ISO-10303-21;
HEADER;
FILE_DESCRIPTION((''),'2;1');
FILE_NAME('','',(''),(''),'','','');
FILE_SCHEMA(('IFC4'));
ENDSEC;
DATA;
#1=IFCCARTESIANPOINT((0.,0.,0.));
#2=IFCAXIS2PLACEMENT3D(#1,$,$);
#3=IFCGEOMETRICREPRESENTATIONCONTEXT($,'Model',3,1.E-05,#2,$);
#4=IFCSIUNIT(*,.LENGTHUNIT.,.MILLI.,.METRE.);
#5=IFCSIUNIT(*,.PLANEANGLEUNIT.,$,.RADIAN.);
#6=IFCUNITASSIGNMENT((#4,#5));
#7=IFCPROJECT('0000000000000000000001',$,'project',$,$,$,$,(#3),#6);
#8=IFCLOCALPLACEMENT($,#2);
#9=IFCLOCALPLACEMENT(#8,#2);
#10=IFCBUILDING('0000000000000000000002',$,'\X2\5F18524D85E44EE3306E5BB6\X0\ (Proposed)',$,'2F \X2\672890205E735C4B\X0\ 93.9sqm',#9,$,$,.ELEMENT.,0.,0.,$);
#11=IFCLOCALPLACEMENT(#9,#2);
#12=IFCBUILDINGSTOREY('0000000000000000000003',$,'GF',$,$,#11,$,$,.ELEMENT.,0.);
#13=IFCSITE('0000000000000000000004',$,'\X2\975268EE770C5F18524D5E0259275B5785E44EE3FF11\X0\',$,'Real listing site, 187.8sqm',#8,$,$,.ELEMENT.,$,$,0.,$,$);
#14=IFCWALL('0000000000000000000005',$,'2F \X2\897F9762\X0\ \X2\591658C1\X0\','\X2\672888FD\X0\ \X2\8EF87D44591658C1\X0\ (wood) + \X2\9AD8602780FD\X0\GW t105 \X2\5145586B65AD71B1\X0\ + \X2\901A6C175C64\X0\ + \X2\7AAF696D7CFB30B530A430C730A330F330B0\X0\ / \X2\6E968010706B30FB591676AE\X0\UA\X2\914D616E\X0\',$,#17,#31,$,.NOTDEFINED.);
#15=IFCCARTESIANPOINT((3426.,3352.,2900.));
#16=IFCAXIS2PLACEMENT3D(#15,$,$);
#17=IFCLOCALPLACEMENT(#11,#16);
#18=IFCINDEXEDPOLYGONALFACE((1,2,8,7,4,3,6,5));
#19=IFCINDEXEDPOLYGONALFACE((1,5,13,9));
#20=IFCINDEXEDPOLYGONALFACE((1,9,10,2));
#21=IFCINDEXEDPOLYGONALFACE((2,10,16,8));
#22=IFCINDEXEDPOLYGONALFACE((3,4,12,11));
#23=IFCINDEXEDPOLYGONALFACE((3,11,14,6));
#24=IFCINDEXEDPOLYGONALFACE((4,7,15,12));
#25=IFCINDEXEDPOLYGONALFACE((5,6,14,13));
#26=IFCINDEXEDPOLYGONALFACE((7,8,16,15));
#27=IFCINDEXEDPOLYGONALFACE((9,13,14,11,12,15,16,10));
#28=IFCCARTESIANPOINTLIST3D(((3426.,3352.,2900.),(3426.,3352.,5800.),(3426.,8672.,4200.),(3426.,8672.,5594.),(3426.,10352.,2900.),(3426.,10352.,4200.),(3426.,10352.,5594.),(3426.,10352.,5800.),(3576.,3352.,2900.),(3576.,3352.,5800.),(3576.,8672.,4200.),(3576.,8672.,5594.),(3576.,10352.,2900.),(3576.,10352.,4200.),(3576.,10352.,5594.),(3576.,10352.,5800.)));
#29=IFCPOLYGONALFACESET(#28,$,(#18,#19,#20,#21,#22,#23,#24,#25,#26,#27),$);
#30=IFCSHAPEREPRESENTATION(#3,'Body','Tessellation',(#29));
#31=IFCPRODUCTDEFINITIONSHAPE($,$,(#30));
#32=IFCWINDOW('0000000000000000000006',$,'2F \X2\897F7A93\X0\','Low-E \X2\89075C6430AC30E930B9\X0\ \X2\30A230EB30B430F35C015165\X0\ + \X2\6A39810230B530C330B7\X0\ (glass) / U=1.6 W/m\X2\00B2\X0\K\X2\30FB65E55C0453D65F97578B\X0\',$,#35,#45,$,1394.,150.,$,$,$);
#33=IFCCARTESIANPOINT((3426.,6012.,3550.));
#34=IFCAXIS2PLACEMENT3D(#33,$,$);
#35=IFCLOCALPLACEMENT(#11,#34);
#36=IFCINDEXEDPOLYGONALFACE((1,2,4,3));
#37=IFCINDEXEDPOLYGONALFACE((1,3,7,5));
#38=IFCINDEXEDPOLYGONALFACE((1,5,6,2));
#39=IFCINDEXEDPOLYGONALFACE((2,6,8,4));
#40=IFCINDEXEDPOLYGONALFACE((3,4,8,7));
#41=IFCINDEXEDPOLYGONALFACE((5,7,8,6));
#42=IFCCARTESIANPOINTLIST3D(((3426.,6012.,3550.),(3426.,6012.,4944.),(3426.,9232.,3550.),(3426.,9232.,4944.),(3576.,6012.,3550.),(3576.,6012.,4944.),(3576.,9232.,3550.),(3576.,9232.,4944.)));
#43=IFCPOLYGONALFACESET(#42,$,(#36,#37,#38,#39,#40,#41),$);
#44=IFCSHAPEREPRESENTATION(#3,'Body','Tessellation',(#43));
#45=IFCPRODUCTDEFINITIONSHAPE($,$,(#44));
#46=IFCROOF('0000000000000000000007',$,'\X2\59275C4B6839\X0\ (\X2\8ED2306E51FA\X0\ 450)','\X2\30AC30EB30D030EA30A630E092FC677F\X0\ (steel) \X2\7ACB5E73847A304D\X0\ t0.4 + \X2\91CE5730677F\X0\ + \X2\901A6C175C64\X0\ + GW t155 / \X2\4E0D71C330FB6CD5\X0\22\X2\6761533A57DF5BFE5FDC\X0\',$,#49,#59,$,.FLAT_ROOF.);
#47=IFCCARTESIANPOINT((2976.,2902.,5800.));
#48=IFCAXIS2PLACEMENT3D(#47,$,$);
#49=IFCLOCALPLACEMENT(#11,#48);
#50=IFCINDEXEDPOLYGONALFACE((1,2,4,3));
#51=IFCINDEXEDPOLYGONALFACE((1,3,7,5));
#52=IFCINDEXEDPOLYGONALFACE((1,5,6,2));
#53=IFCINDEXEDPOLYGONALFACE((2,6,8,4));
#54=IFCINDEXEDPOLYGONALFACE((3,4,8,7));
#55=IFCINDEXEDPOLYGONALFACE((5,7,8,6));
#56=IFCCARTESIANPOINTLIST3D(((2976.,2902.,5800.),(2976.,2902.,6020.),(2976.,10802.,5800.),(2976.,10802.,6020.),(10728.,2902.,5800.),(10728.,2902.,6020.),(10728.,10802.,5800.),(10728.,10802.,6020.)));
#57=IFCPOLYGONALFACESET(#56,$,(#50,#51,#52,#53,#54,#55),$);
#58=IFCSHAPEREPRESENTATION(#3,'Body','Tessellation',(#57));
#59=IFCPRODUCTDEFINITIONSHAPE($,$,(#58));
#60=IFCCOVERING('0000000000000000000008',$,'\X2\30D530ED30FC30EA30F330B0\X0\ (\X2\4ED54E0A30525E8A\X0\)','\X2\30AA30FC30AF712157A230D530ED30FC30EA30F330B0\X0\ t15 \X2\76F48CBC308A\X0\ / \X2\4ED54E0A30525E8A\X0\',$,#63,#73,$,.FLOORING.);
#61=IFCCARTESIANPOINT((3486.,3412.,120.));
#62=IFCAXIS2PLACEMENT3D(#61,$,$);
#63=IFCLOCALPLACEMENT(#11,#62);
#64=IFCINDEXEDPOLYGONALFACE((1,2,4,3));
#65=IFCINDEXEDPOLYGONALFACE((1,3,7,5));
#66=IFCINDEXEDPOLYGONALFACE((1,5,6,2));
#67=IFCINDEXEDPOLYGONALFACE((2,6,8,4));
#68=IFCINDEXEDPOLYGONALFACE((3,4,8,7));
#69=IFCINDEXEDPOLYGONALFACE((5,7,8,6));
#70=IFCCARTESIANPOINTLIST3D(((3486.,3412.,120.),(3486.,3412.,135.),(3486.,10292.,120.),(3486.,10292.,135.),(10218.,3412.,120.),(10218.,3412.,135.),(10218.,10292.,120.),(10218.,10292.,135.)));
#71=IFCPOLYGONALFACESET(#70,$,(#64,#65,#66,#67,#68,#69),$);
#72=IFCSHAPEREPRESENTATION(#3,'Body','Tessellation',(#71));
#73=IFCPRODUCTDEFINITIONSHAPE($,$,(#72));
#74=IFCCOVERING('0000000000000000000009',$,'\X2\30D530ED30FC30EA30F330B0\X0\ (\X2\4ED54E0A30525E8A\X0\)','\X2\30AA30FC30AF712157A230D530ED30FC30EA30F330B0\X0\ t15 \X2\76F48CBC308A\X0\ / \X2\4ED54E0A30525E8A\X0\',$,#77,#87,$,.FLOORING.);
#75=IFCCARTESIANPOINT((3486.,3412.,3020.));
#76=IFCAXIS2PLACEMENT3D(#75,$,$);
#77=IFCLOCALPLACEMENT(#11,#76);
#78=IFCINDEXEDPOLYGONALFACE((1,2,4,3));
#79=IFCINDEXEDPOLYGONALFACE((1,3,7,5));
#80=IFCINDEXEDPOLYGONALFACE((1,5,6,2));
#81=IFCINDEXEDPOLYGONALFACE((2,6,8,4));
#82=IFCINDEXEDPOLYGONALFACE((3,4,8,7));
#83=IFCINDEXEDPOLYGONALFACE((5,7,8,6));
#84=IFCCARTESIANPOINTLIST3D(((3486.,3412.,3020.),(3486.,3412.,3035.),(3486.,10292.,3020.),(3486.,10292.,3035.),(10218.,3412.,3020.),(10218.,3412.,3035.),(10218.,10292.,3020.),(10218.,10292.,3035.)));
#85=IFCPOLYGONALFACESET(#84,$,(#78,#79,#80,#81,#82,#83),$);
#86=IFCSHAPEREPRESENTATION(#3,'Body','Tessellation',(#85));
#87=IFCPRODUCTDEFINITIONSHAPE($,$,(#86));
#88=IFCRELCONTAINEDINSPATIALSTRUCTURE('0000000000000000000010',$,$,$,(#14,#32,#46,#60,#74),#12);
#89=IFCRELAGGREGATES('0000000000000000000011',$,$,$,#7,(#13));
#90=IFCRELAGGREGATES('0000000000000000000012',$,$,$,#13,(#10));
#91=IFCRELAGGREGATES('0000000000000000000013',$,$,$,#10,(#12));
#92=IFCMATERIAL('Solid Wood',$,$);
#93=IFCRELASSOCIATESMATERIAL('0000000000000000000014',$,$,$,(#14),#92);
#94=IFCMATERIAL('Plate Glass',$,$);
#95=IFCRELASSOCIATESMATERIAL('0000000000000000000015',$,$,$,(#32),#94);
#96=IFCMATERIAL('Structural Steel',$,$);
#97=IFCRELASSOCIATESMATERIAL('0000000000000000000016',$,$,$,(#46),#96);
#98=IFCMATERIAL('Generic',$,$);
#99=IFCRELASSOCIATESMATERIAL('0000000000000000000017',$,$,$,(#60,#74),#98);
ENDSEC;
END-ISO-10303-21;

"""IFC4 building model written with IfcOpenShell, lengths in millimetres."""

from ifc_helpers import new_model, si_unit, frame, frame_2d, origin, place, context, project, spatial, rectangle, extrude, material, element, fill, save


model = new_model("IFC4")

# Units and contexts
model_context = context("Model", 3, precision=1e-05, world=origin())
ifc_project = project(units=[si_unit("LENGTHUNIT", "METRE", prefix="MILLI"), si_unit("PLANEANGLEUNIT", "RADIAN")], contexts=[model_context])

# Site, building, storey
site_placement = place(None, origin())
site = spatial("IfcSite", under=ifc_project, at=site_placement, Name="青森県弘前市大字藤代１", ObjectType="Real listing site, 187.8sqm", CompositionType="ELEMENT", RefElevation=0.0)
building_placement = place(site_placement, origin())
building = spatial("IfcBuilding", under=site, at=building_placement, Name="弘前藤代の家 (Proposed)", ObjectType="2F 木造平屋 93.9sqm", CompositionType="ELEMENT", ElevationOfRefHeight=0.0, ElevationOfTerrain=0.0)
storey_placement = place(building_placement, origin())
storey = spatial("IfcBuildingStorey", under=building, at=storey_placement, Name="GF", CompositionType="ELEMENT", Elevation=0.0)

# Shared definitions
ifc_material_1 = material(Name="Solid Wood")

# Shared definitions
ifc_material_2 = material(Name="Plate Glass")

# Wall, opening, window
wall_1_placement = place(storey_placement, frame((3426.0, 3352.0, 2900.0)))
wall_1 = element("IfcWall", 1, at=wall_1_placement, inside=storey, material=ifc_material_1, Name="2F 西面 外壁", Description="木製 軸組外壁 (wood) + 高性能GW t105 充填断熱 + 通気層 + 窯業系サイディング / 準耐火・外皮UA配慮", PredefinedType="NOTDEFINED", context=model_context, shape_type="SweptSolid", body=[
    extrude(rectangle(XDim=150.0, YDim=7000.0, at=frame_2d((75.0, 3500.0))), frame((3426.0, 3352.0, 2900.0)), (0.0, 0.0, 1.0), 2900.0),
])
opening_1_placement = place(storey_placement, frame((3426.0, 6012.0, 3550.0)))
opening_1 = element("IfcOpeningElement", 2, at=opening_1_placement, cuts=wall_1, PredefinedType="NOTDEFINED", context=model_context, shape_type="SweptSolid", body=[
    extrude(rectangle(XDim=150.0, YDim=3220.0, at=frame_2d((75.0, 1610.0))), frame((3426.0, 6012.0, 3550.0)), (0.0, 0.0, 1.0), 1394.0),
])
window_1_placement = place(storey_placement, frame((3426.0, 6012.0, 3550.0)))
window_1 = element("IfcWindow", 3, at=window_1_placement, inside=storey, material=ifc_material_2, Name="2F 西窓", Description="Low-E 複層ガラス アルゴン封入 + 樹脂サッシ (glass) / U=1.6 W/m²K・日射取得型", OverallHeight=1394.0, OverallWidth=150.0, context=model_context, shape_type="SweptSolid", body=[
    extrude(rectangle(XDim=150.0, YDim=3220.0, at=frame_2d((75.0, 1610.0))), frame((3426.0, 6012.0, 3550.0)), (0.0, 0.0, 1.0), 1394.0),
])
fill(opening_1, window_1)

# Roof
ifc_material_3 = material(Name="Structural Steel")
roof_placement = place(storey_placement, frame((2976.0, 2902.0, 5800.0)))
element("IfcRoof", 4, at=roof_placement, inside=storey, material=ifc_material_3, Name="大屋根 (軒の出 450)", Description="ガルバリウム鋼板 (steel) 立平葺き t0.4 + 野地板 + 通気層 + GW t155 / 不燃・法22条区域対応", PredefinedType="FLAT_ROOF", context=model_context, shape_type="SweptSolid", body=[
    extrude(rectangle(XDim=7752.0, YDim=7900.0, at=frame_2d((3876.0, 3950.0))), frame((2976.0, 2902.0, 5800.0)), (0.0, 0.0, 1.0), 220.0),
])

# Coverings
ifc_material_4 = material(Name="Generic")
covering_1_placement = place(storey_placement, frame((3486.0, 3412.0, 120.0)))
element("IfcCovering", 5, at=covering_1_placement, inside=storey, material=ifc_material_4, Name="フローリング (仕上げ床)", Description="オーク無垢フローリング t15 直貼り / 仕上げ床", PredefinedType="FLOORING", context=model_context, shape_type="SweptSolid", body=[
    extrude(rectangle(XDim=6732.0, YDim=6880.0, at=frame_2d((3366.0, 3440.0))), frame((3486.0, 3412.0, 120.0)), (0.0, 0.0, 1.0), 15.0),
])
covering_2_placement = place(storey_placement, frame((3486.0, 3412.0, 3020.0)))
element("IfcCovering", 6, at=covering_2_placement, inside=storey, material=ifc_material_4, Name="フローリング (仕上げ床)", Description="オーク無垢フローリング t15 直貼り / 仕上げ床", PredefinedType="FLOORING", context=model_context, shape_type="SweptSolid", body=[
    extrude(rectangle(XDim=6732.0, YDim=6880.0, at=frame_2d((3366.0, 3440.0))), frame((3486.0, 3412.0, 3020.0)), (0.0, 0.0, 1.0), 15.0),
])

save(model, "model.ifc")
